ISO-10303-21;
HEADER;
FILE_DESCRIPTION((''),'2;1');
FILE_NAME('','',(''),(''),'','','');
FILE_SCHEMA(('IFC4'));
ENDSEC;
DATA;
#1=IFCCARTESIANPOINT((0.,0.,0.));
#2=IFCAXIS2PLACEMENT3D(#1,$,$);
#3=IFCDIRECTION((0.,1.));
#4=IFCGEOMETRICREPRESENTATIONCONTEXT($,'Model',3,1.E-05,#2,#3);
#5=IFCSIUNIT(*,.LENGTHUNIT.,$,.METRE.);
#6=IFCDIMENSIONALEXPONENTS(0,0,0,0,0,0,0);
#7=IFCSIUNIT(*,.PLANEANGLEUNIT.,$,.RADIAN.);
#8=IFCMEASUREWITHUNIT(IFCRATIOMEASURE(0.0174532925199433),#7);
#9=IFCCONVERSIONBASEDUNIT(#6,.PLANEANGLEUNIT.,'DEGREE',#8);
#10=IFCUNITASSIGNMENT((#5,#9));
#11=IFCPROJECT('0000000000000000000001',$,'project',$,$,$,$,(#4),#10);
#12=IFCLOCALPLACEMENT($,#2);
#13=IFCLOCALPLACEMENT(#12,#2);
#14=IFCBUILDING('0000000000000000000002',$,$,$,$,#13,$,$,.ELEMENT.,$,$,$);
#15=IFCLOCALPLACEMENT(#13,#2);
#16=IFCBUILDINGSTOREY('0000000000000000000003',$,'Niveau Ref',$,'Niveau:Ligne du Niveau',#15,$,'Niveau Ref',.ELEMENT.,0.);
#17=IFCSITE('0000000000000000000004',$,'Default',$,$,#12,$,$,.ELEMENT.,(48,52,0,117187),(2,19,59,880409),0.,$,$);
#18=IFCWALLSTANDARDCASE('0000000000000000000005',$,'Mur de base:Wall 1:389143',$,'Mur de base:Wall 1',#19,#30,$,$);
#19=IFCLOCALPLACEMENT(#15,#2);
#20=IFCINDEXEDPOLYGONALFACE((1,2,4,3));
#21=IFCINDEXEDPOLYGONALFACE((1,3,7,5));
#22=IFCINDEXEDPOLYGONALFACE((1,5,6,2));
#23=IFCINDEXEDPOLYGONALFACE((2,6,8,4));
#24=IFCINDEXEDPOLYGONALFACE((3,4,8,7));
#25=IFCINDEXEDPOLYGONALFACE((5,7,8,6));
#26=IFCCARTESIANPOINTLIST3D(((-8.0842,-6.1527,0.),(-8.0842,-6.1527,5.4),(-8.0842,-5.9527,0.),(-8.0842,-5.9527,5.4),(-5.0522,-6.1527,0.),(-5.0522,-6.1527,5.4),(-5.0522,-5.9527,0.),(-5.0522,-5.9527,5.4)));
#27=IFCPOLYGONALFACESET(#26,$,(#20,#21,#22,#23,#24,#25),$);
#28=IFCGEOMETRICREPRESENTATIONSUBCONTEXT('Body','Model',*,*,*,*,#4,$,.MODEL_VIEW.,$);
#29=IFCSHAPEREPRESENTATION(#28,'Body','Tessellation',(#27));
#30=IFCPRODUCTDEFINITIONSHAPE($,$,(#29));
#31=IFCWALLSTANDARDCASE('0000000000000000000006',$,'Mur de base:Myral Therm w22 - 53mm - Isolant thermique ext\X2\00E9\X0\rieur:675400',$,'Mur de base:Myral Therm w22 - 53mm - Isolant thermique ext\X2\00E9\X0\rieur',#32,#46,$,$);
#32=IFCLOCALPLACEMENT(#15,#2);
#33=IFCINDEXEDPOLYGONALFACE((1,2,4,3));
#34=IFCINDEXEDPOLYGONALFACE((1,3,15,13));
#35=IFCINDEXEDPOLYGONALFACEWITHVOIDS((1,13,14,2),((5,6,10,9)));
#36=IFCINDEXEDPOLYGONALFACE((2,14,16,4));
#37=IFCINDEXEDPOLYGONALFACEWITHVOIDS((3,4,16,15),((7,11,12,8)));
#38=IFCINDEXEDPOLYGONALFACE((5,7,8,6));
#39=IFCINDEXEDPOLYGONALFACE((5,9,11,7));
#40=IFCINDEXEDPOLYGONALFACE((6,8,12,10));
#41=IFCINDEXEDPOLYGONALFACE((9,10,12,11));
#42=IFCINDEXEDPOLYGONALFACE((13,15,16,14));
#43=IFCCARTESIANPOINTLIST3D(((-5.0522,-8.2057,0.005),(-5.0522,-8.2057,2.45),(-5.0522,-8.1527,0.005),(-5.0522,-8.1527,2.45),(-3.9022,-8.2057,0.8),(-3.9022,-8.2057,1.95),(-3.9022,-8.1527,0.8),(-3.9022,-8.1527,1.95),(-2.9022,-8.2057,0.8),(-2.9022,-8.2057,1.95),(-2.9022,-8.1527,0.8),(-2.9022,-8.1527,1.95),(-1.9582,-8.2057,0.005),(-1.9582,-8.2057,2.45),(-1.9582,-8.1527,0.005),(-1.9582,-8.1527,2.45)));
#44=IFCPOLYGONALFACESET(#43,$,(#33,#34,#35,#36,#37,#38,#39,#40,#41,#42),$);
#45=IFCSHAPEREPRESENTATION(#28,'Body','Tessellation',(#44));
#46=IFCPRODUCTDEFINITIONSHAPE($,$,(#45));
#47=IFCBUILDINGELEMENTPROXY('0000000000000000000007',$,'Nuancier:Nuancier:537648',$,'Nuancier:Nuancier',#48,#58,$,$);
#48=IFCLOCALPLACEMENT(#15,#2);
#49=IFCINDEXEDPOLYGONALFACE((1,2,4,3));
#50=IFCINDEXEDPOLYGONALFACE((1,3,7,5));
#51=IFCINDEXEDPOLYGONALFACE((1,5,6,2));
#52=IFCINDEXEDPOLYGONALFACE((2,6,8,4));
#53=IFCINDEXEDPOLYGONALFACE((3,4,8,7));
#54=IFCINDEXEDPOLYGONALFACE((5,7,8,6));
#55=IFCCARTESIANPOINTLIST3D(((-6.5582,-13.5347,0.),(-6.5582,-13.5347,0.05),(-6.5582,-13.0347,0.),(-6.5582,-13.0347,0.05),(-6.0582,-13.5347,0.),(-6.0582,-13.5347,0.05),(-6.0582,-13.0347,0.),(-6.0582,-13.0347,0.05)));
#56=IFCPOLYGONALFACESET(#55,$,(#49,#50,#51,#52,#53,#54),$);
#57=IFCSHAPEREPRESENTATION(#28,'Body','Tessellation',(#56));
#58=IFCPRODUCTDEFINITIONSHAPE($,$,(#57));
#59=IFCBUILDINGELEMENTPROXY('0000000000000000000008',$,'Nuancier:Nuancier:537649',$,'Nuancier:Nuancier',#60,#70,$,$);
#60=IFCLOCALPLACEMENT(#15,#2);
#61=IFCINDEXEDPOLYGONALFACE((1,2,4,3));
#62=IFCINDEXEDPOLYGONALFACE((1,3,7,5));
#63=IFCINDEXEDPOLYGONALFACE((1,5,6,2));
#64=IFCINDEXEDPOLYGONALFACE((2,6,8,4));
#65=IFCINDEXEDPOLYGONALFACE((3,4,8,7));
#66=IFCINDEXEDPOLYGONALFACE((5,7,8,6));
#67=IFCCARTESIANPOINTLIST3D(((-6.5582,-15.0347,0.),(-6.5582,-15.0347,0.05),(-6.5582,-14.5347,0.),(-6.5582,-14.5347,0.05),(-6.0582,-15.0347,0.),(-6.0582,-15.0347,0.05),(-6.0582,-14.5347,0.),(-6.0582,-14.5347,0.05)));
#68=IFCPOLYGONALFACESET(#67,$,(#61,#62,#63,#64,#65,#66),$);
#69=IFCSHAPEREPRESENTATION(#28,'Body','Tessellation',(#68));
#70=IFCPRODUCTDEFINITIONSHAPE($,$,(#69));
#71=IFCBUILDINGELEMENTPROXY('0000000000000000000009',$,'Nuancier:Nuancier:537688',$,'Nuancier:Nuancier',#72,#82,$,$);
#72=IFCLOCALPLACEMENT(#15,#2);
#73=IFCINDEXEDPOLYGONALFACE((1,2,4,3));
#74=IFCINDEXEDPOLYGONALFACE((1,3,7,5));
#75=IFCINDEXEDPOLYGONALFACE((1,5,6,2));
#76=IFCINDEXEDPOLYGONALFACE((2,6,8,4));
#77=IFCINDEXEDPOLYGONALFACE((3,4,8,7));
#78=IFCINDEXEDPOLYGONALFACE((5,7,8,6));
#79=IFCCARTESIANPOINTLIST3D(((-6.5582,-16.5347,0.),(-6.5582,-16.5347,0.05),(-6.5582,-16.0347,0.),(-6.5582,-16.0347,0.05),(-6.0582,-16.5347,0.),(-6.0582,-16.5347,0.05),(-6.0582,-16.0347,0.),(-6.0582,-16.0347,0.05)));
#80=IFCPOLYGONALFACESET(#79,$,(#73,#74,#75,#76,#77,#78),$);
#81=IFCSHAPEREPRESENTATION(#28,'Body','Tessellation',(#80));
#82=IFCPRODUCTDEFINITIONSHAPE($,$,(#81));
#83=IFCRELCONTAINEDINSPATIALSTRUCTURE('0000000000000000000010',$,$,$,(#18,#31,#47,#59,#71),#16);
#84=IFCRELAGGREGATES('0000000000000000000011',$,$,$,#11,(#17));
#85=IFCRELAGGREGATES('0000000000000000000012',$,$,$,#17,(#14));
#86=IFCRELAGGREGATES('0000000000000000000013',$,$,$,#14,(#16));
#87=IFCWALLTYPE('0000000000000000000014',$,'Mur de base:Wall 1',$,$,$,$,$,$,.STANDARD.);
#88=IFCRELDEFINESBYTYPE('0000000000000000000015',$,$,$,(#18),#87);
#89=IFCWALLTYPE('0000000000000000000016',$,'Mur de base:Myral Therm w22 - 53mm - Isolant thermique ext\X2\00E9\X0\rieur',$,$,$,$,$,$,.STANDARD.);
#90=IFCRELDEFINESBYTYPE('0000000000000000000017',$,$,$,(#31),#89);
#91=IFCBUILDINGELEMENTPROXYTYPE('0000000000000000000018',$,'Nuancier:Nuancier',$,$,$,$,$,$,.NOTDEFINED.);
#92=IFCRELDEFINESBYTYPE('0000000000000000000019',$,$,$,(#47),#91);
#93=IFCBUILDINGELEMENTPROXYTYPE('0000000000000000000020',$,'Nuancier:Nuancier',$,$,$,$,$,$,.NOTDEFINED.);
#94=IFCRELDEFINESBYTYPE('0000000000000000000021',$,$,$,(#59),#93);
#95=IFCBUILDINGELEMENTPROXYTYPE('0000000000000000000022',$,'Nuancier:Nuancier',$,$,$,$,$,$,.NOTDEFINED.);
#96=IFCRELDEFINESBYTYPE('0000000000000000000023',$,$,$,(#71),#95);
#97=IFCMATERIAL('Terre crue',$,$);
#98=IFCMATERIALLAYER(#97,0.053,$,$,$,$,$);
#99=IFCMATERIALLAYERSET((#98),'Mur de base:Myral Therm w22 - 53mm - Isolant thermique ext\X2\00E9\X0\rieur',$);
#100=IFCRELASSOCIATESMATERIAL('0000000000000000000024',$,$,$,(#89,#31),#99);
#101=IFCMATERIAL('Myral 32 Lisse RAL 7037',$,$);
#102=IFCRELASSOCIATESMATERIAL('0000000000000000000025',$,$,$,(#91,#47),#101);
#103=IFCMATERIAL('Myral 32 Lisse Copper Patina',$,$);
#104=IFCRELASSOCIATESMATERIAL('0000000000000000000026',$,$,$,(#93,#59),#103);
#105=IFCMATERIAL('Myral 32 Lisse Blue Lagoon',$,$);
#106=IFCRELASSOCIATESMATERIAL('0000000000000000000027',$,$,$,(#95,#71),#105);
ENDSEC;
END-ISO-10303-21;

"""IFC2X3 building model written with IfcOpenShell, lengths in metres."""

from ifc_helpers import new_model, entity, si_unit, converted_unit, direction, frame, frame_2d, origin, origin_2d_with_axis, place, context, subcontext, project, spatial, rectangle, extrude, source, transform, mapped, material, layer, layer_set, layer_usage, type_object, type_shapes, element, save


model = new_model("IFC2X3")

# Units and contexts
model_context = context("Model", 3, precision=1e-05, world=origin(), true_north=direction((0.0, 1.0)))
body_context = subcontext(model_context, "Body", "Model", "MODEL_VIEW")
ifc_project = project(units=[si_unit("LENGTHUNIT", "METRE"), converted_unit("PLANEANGLEUNIT", "DEGREE", entity("IfcRatioMeasure", 0.0174532925199433), si_unit("PLANEANGLEUNIT", "RADIAN"), dimensions=[0, 0, 0, 0, 0, 0, 0])], contexts=[model_context])

# Site, building, storey
site_placement = place(None, origin())
site = spatial("IfcSite", under=ifc_project, at=site_placement, Name="Default", CompositionType="ELEMENT", RefLatitude=(48, 52, 0, 117187), RefLongitude=(2, 19, 59, 880409), RefElevation=0.0)
building_placement = place(site_placement, origin())
building = spatial("IfcBuilding", under=site, at=building_placement, CompositionType="ELEMENT")
storey_placement = place(building_placement, origin())
storey = spatial("IfcBuildingStorey", under=building, at=storey_placement, Name="Niveau Ref", ObjectType="Niveau:Ligne du Niveau", LongName="Niveau Ref", CompositionType="ELEMENT", Elevation=0.0)

# Wall
wall_type_1 = type_object("IfcWallType", Name="Mur de base:Wall 1", PredefinedType="STANDARD")
wall_1_placement = place(storey_placement, frame((-5.0522, -6.0527, 0.0), z_axis=(0.0, 0.0, 1.0), x_axis=(-1.0, 0.0, 0.0)))
element("IfcWallStandardCase", 1, at=wall_1_placement, inside=storey, type_object=wall_type_1, Name="Mur de base:Wall 1:389143", ObjectType="Mur de base:Wall 1", context=body_context, shape_type="SweptSolid", body=[
    extrude(rectangle(XDim=3.032, YDim=0.2, at=frame_2d((1.516, 0.0), x_axis=(-1.0, 0.0))), origin(), (0.0, 0.0, 1.0), 5.4),
])

# Wall, opening
ifc_material_1 = material(Name="Terre crue")
ifc_layer = layer(ifc_material_1, 0.053)
ifc_layer_set = layer_set([ifc_layer], Name="Mur de base:Myral Therm w22 - 53mm - Isolant thermique extérieur")
ifc_layer_usage = layer_usage(ifc_layer_set, "AXIS2", "NEGATIVE", 0.0265)
wall_type_2 = type_object("IfcWallType", Name="Mur de base:Myral Therm w22 - 53mm - Isolant thermique extérieur", PredefinedType="STANDARD", material=ifc_layer_set)
wall_2_placement = place(storey_placement, frame((-5.0522, -8.1792, 0.005)))
wall_2 = element("IfcWallStandardCase", 2, at=wall_2_placement, inside=storey, type_object=wall_type_2, material=ifc_layer_usage, Name="Mur de base:Myral Therm w22 - 53mm - Isolant thermique extérieur:675400", ObjectType="Mur de base:Myral Therm w22 - 53mm - Isolant thermique extérieur", context=body_context, shape_type="SweptSolid", body=[
    extrude(rectangle(XDim=3.094, YDim=0.053, at=frame_2d((1.547, 0.0), x_axis=(-1.0, 0.0))), origin(), (0.0, 0.0, 1.0), 2.445),
])
opening_placement = place(wall_2_placement, origin())
element("IfcOpeningElement", 3, at=opening_placement, cuts=wall_2, ObjectType="Opening", context=body_context, shape_type="SweptSolid", body=[
    extrude(rectangle(XDim=1.15, YDim=1.0, at=frame_2d((0.0, 0.0), x_axis=(0.0, 1.0))), frame((1.65, 0.0265, 1.37), z_axis=(0.0, -1.0, 0.0), x_axis=(-1.0, 0.0, 0.0)), (0.0, 0.0, 1.0), 0.053),
])

# Building element proxies
ifc_material_2 = material(Name="Myral 32 Lisse RAL 7037")
building_element_proxy_type_1 = type_object("IfcBuildingElementProxyType", Name="Nuancier:Nuancier", PredefinedType="NOTDEFINED", material=ifc_material_2)
shared_shape_1 = source(origin(), body_context, "Body", "SweptSolid", [
    extrude(rectangle(XDim=0.5, YDim=0.5, at=origin_2d_with_axis()), frame((0.0, 0.0, 0.0), z_axis=(0.0, 0.0, 1.0), x_axis=(-1.0, 0.0, 0.0)), (0.0, 0.0, 1.0), 0.05),
])
type_shapes(building_element_proxy_type_1, [shared_shape_1])
proxy_1_placement = place(storey_placement, frame((-6.3082, -13.2847, 0.0)))
element("IfcBuildingElementProxy", 4, at=proxy_1_placement, inside=storey, type_object=building_element_proxy_type_1, material=ifc_material_2, Name="Nuancier:Nuancier:537648", ObjectType="Nuancier:Nuancier", context=body_context, shape_type="MappedRepresentation", body=[
    mapped(shared_shape_1, transform((0.0, 0.0, 0.0), scale=1.0)),
])
ifc_material_3 = material(Name="Myral 32 Lisse Copper Patina")
building_element_proxy_type_2 = type_object("IfcBuildingElementProxyType", Name="Nuancier:Nuancier", PredefinedType="NOTDEFINED", material=ifc_material_3)
shared_shape_2 = source(origin(), body_context, "Body", "SweptSolid", [
    extrude(rectangle(XDim=0.5, YDim=0.5, at=origin_2d_with_axis()), frame((0.0, 0.0, 0.0), z_axis=(0.0, 0.0, 1.0), x_axis=(-1.0, 0.0, 0.0)), (0.0, 0.0, 1.0), 0.05),
])
type_shapes(building_element_proxy_type_2, [shared_shape_2])
proxy_2_placement = place(storey_placement, frame((-6.3082, -14.7847, 0.0)))
element("IfcBuildingElementProxy", 5, at=proxy_2_placement, inside=storey, type_object=building_element_proxy_type_2, material=ifc_material_3, Name="Nuancier:Nuancier:537649", ObjectType="Nuancier:Nuancier", context=body_context, shape_type="MappedRepresentation", body=[
    mapped(shared_shape_2, transform((0.0, 0.0, 0.0), scale=1.0)),
])
ifc_material_4 = material(Name="Myral 32 Lisse Blue Lagoon")
building_element_proxy_type_3 = type_object("IfcBuildingElementProxyType", Name="Nuancier:Nuancier", PredefinedType="NOTDEFINED", material=ifc_material_4)
shared_shape_3 = source(origin(), body_context, "Body", "SweptSolid", [
    extrude(rectangle(XDim=0.5, YDim=0.5, at=origin_2d_with_axis()), frame((0.0, 0.0, 0.0), z_axis=(0.0, 0.0, 1.0), x_axis=(-1.0, 0.0, 0.0)), (0.0, 0.0, 1.0), 0.05),
])
type_shapes(building_element_proxy_type_3, [shared_shape_3])
proxy_3_placement = place(storey_placement, frame((-6.3082, -16.2847, 0.0)))
element("IfcBuildingElementProxy", 6, at=proxy_3_placement, inside=storey, type_object=building_element_proxy_type_3, material=ifc_material_4, Name="Nuancier:Nuancier:537688", ObjectType="Nuancier:Nuancier", context=body_context, shape_type="MappedRepresentation", body=[
    mapped(shared_shape_3, transform((0.0, 0.0, 0.0), scale=1.0)),
])

save(model, "model.ifc")
